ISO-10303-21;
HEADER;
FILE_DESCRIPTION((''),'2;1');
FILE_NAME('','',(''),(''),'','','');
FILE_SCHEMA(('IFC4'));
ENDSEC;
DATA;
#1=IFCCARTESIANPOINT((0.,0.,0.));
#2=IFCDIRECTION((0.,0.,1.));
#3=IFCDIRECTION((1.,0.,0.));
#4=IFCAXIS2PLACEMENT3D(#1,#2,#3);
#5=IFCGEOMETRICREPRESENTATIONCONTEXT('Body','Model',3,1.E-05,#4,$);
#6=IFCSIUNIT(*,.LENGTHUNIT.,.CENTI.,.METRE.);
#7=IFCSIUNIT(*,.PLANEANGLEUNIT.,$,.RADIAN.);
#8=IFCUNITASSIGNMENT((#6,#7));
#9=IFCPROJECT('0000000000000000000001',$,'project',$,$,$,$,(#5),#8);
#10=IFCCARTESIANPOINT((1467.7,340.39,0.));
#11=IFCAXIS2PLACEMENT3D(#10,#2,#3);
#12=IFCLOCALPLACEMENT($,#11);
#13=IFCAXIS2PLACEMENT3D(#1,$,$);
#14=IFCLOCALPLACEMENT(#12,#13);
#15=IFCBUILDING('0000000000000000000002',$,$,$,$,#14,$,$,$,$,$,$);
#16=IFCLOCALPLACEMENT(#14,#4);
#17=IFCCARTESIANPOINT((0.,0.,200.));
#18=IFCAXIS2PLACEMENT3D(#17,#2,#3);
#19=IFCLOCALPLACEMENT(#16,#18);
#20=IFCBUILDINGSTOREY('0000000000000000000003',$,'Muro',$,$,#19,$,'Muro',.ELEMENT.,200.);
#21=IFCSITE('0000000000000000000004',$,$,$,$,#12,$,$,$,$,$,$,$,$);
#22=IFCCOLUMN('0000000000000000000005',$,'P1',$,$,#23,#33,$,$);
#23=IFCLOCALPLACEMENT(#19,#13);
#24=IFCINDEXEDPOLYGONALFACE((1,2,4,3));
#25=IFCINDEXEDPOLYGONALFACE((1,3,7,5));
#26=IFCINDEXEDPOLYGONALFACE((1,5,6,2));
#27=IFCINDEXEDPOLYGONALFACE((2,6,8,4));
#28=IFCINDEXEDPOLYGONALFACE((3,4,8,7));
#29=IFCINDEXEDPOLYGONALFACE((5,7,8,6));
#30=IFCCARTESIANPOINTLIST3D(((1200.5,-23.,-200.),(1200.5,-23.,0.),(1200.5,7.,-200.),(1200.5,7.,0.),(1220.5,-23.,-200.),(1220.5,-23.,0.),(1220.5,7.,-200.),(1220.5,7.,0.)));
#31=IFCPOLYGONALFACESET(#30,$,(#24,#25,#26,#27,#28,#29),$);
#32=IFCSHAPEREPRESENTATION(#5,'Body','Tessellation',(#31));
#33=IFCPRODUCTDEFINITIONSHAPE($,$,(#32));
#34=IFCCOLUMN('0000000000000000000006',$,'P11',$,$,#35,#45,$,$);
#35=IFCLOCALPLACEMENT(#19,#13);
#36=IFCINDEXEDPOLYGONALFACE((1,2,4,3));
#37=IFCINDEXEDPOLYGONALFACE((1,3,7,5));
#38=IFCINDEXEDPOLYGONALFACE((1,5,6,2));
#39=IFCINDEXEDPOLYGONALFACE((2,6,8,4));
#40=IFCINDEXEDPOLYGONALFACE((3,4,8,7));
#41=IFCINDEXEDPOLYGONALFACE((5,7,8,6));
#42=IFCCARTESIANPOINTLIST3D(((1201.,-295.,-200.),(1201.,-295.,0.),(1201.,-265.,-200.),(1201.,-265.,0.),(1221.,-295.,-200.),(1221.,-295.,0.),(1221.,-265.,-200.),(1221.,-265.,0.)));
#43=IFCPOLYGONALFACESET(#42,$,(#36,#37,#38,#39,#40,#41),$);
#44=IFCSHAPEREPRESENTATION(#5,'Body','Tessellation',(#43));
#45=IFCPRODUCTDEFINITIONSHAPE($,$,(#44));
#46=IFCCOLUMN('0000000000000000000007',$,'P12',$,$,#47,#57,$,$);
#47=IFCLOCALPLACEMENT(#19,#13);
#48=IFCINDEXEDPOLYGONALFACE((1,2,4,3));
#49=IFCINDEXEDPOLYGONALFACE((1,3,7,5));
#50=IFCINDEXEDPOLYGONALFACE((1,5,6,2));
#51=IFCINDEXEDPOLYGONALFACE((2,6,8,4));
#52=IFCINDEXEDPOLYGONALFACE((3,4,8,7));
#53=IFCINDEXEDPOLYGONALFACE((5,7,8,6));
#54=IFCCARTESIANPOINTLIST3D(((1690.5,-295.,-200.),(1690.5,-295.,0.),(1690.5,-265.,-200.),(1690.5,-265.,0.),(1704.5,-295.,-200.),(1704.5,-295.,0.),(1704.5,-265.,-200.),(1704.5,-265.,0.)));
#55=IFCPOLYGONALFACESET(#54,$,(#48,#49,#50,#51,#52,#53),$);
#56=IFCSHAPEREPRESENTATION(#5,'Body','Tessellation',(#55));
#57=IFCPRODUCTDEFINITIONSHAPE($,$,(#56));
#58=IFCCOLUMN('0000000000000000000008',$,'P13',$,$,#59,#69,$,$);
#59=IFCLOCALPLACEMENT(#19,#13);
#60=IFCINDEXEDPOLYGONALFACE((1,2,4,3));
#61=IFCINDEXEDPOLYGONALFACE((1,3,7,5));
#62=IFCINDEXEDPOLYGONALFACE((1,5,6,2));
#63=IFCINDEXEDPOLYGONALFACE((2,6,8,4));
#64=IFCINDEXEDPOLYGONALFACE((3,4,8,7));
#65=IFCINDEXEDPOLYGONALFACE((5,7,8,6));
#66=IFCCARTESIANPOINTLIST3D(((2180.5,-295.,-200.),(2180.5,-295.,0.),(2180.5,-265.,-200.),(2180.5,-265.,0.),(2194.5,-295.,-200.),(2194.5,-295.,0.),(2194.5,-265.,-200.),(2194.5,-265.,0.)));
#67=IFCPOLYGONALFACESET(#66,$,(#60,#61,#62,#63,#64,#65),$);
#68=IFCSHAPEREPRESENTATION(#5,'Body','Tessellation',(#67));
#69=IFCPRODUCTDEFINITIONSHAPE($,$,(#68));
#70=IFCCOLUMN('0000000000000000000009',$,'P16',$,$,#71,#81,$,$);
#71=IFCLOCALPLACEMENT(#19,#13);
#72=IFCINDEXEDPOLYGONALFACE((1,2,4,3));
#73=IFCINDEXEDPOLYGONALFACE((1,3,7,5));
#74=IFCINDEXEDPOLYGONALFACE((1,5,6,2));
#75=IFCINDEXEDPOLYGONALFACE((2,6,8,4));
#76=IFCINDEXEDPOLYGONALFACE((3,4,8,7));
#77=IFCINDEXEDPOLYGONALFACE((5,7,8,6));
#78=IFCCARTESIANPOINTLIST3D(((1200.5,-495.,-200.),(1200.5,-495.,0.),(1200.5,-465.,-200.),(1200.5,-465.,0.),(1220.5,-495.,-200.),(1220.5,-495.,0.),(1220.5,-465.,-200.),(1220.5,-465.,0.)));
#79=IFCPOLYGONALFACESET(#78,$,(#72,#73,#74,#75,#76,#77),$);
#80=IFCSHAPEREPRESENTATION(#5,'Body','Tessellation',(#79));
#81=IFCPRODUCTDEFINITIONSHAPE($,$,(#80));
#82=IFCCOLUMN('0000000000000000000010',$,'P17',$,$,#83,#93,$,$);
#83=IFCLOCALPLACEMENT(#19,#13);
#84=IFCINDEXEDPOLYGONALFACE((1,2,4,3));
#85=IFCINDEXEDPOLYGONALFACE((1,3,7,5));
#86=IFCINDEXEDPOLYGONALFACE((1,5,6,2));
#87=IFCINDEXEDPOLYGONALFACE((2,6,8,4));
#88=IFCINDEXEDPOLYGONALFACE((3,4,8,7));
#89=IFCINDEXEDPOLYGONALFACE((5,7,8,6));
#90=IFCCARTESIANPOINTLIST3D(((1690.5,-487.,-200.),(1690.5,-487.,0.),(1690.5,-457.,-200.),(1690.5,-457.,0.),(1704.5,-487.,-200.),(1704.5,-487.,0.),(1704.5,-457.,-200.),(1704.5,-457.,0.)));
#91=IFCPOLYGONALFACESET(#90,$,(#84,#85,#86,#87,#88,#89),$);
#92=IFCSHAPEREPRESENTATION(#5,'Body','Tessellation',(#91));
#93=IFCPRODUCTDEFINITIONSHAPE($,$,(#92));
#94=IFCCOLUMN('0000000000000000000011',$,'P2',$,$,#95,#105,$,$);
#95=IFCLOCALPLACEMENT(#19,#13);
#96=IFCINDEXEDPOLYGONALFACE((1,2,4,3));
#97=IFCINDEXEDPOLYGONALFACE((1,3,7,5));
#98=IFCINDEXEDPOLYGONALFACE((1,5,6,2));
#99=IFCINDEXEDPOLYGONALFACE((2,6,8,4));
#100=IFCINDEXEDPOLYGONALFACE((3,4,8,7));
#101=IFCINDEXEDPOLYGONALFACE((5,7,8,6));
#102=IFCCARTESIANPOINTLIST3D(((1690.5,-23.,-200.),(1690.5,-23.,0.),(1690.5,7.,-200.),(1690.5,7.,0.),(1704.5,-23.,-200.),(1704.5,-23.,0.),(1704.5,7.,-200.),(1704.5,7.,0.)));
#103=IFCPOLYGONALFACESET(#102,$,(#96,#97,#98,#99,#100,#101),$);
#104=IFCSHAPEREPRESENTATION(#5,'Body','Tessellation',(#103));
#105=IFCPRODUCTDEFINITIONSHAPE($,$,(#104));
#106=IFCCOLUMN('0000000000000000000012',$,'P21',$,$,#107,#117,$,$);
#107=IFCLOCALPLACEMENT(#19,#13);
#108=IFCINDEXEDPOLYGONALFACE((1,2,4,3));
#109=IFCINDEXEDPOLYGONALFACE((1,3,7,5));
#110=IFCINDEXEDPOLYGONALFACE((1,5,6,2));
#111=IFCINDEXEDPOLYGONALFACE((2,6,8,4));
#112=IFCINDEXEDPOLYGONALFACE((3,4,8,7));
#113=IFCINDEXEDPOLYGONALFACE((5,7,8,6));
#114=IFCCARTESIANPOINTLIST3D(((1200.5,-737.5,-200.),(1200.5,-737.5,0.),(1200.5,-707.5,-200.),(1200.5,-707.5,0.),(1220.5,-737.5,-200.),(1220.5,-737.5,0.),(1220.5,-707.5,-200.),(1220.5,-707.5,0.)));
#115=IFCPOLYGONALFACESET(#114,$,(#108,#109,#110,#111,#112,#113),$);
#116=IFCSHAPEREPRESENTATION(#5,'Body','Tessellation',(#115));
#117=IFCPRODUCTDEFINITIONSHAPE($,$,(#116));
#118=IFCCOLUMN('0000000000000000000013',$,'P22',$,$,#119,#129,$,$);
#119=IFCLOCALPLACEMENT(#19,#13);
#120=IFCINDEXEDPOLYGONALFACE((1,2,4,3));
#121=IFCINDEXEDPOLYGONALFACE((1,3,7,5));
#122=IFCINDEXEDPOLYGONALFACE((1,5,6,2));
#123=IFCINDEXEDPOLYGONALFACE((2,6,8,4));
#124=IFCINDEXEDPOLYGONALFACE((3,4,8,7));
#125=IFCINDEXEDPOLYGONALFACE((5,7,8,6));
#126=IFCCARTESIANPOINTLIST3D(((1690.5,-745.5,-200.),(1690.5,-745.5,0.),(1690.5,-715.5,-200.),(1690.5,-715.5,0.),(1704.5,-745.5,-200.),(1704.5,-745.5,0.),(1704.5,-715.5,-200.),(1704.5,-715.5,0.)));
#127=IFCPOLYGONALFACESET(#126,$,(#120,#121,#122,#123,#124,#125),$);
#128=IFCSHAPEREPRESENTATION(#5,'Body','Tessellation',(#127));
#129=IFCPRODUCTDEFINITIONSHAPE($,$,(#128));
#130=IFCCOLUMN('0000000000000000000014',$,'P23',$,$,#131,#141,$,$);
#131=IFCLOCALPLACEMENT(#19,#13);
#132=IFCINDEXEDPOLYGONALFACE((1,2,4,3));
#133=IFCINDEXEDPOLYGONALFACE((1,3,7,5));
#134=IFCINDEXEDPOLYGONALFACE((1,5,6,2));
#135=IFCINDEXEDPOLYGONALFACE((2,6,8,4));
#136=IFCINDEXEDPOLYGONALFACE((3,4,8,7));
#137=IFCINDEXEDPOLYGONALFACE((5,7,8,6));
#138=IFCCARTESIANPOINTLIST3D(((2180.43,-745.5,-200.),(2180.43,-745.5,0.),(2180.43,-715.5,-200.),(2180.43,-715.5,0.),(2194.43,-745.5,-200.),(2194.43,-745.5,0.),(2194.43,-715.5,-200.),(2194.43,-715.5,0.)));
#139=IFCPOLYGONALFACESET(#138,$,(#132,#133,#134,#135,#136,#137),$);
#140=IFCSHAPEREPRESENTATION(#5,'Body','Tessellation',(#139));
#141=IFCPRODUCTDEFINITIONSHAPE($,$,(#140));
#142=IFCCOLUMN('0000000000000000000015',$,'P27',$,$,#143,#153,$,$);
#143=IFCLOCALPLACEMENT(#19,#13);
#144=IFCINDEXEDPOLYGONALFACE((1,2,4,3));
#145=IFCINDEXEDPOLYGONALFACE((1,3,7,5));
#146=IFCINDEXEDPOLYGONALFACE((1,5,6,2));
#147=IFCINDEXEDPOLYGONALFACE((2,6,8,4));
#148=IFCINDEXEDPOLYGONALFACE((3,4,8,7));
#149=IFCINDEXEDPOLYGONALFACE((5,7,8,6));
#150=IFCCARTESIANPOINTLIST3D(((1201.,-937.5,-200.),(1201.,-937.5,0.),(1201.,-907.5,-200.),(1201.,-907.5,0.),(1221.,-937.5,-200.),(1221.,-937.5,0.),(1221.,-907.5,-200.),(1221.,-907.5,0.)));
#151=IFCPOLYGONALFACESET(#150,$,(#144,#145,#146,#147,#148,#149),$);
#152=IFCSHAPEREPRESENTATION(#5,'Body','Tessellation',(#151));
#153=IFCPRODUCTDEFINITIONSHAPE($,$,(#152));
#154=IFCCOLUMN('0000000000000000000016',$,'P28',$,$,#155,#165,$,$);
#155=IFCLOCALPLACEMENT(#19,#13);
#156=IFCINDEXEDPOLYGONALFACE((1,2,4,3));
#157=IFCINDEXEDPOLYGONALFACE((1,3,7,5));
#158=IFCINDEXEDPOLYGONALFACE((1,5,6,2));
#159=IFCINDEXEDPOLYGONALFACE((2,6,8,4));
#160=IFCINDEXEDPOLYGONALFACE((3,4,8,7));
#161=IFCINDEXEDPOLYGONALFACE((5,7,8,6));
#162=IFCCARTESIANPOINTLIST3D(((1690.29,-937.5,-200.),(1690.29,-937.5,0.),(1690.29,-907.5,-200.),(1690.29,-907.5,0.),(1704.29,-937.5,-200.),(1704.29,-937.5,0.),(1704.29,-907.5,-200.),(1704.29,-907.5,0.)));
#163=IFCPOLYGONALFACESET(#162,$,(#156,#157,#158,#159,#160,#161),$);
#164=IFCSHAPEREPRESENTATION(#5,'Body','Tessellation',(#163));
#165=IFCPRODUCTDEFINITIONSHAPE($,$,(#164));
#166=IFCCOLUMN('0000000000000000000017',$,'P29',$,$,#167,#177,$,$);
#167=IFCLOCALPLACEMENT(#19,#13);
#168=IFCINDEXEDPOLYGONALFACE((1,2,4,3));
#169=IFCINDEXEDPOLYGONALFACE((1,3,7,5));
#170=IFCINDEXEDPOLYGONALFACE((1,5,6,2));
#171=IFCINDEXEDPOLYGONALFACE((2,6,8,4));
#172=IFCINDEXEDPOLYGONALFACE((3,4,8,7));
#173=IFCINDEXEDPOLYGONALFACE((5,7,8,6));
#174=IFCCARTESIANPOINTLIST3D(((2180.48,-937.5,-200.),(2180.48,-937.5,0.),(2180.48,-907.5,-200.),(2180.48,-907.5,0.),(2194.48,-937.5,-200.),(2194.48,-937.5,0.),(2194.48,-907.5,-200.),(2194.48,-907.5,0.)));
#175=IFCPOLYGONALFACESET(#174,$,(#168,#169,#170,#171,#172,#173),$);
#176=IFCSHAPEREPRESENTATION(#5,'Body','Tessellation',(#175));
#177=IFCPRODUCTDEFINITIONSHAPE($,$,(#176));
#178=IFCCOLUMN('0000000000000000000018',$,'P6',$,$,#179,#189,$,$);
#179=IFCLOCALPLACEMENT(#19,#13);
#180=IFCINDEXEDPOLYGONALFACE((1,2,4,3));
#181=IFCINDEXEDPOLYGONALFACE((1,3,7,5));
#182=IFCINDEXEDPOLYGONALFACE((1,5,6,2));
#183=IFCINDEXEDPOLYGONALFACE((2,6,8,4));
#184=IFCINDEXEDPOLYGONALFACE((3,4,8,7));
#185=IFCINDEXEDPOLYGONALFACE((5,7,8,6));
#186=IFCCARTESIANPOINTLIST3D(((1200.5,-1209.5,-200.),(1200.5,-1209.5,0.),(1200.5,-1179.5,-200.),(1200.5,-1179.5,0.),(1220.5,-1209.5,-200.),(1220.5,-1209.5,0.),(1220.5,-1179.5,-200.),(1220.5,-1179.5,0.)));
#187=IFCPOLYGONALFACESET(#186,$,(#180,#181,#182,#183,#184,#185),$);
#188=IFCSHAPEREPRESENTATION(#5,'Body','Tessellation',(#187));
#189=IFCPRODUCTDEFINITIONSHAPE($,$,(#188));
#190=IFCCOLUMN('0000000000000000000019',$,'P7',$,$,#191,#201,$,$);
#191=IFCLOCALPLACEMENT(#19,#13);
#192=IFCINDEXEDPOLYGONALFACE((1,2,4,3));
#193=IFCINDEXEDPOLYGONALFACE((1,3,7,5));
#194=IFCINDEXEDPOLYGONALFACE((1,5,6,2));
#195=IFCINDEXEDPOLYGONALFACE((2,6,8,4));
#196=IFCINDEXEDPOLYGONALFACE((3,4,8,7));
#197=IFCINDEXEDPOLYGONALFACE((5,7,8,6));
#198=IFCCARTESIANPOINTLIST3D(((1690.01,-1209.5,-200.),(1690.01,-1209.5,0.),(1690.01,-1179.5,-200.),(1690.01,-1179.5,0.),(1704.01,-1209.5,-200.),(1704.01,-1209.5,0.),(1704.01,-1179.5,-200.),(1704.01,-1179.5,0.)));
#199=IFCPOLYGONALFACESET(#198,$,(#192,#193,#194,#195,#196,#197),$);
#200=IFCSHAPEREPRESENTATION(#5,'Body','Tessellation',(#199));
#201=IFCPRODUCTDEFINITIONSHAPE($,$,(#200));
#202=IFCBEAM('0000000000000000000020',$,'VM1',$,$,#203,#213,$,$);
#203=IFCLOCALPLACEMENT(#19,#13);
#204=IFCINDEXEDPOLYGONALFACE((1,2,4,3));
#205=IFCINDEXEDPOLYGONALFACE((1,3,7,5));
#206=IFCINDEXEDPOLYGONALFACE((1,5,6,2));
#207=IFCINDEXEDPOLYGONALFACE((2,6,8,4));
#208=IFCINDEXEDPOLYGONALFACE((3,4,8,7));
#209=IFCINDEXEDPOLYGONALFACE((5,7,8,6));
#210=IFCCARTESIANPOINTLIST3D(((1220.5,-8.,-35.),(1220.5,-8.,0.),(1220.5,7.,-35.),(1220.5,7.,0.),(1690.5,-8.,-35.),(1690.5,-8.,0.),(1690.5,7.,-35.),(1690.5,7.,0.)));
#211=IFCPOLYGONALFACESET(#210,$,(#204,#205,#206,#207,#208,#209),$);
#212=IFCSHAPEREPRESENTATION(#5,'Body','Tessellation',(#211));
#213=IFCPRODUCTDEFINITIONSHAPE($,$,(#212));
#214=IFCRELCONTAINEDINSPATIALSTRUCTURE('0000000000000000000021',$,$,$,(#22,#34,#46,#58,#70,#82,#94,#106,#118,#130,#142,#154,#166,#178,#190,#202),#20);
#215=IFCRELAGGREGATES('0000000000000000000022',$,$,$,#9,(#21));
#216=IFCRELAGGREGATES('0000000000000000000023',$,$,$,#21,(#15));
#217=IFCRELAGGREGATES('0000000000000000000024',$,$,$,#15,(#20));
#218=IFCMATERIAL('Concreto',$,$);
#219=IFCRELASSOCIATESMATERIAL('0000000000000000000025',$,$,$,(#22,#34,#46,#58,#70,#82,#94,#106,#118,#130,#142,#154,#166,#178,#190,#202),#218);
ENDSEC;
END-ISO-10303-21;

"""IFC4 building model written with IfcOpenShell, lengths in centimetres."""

from ifc_helpers import new_model, si_unit, frame, origin, origin_with_axes, origin_2d_with_axis, place, context, project, spatial, rectangle, extrude, material, element, save


model = new_model("IFC4")

# Units and contexts
model_context = context("Model", 3, precision=1e-05, world=origin_with_axes(), identifier="Body")
ifc_project = project(units=[si_unit("LENGTHUNIT", "METRE", prefix="CENTI"), si_unit("PLANEANGLEUNIT", "RADIAN")], contexts=[model_context])

# Site, building, storey
site_placement = place(None, frame((1467.7, 340.39, 0.0), z_axis=(0.0, 0.0, 1.0), x_axis=(1.0, 0.0, 0.0)))
site = spatial("IfcSite", under=ifc_project, at=site_placement)
building_placement = place(site_placement, origin())
building = spatial("IfcBuilding", under=site, at=building_placement)
placement = place(building_placement, origin_with_axes())
storey_placement = place(placement, frame((0.0, 0.0, 200.0), z_axis=(0.0, 0.0, 1.0), x_axis=(1.0, 0.0, 0.0)))
storey = spatial("IfcBuildingStorey", under=building, at=storey_placement, Name="Muro", LongName="Muro", CompositionType="ELEMENT", Elevation=200.0)

# Columns
ifc_material = material(Name="Concreto")
for number, where, z_axis, x_axis, name in (
    (1, (1210.5, -8.0, 0.0), (0.0, 0.0, 1.0), (1.0, 0.0, 0.0), "P1"),
    (2, (1211.0, -280.0, 0.0), (0.0, 0.0, 1.0), (1.0, 0.0, 0.0), "P11"),
):
    element("IfcColumn", number, at=place(storey_placement, frame(where, z_axis=z_axis, x_axis=x_axis)), inside=storey, material=ifc_material, Name=name, context=model_context, shape_type="SolidModel", body=[
        extrude(rectangle(XDim=20.0, YDim=30.0, at=origin_2d_with_axis()), origin_with_axes(), (0.0, 0.0, -1.0), 200.0),
    ])
for number, where, z_axis, x_axis, name in (
    (3, (1697.5, -280.0, 0.0), (0.0, 0.0, 1.0), (1.0, 0.0, 0.0), "P12"),
    (4, (2187.5, -280.0, 0.0), (0.0, 0.0, 1.0), (1.0, 0.0, 0.0), "P13"),
):
    element("IfcColumn", number, at=place(storey_placement, frame(where, z_axis=z_axis, x_axis=x_axis)), inside=storey, material=ifc_material, Name=name, context=model_context, shape_type="SolidModel", body=[
        extrude(rectangle(XDim=14.0, YDim=30.0, at=origin_2d_with_axis()), origin_with_axes(), (0.0, 0.0, -1.0), 200.0),
    ])
column_1_placement = place(storey_placement, frame((1210.5, -480.0, 0.0), z_axis=(0.0, 0.0, 1.0), x_axis=(1.0, 0.0, 0.0)))
element("IfcColumn", 5, at=column_1_placement, inside=storey, material=ifc_material, Name="P16", context=model_context, shape_type="SolidModel", body=[
    extrude(rectangle(XDim=20.0, YDim=30.0, at=origin_2d_with_axis()), origin_with_axes(), (0.0, 0.0, -1.0), 200.0),
])
column_2_placement = place(storey_placement, frame((1697.5, -472.0, 0.0), z_axis=(0.0, 0.0, 1.0), x_axis=(1.0, 0.0, 0.0)))
element("IfcColumn", 6, at=column_2_placement, inside=storey, material=ifc_material, Name="P17", context=model_context, shape_type="SolidModel", body=[
    extrude(rectangle(XDim=14.0, YDim=30.0, at=origin_2d_with_axis()), frame((0.0, 0.0, 0.0), z_axis=(0.0, 0.0, 1.0), x_axis=(-1.0, 0.0, 0.0)), (0.0, 0.0, -1.0), 200.0),
])
column_3_placement = place(storey_placement, frame((1697.5, -8.0, 0.0), z_axis=(0.0, 0.0, 1.0), x_axis=(1.0, 0.0, 0.0)))
element("IfcColumn", 7, at=column_3_placement, inside=storey, material=ifc_material, Name="P2", context=model_context, shape_type="SolidModel", body=[
    extrude(rectangle(XDim=14.0, YDim=30.0, at=origin_2d_with_axis()), origin_with_axes(), (0.0, 0.0, -1.0), 200.0),
])
column_4_placement = place(storey_placement, frame((1210.5, -722.5, 0.0), z_axis=(0.0, 0.0, 1.0), x_axis=(1.0, 0.0, 0.0)))
element("IfcColumn", 8, at=column_4_placement, inside=storey, material=ifc_material, Name="P21", context=model_context, shape_type="SolidModel", body=[
    extrude(rectangle(XDim=20.0, YDim=30.0, at=origin_2d_with_axis()), origin_with_axes(), (0.0, 0.0, -1.0), 200.0),
])
column_5_placement = place(storey_placement, frame((1697.5, -730.5, 0.0), z_axis=(0.0, 0.0, 1.0), x_axis=(1.0, 0.0, 0.0)))
element("IfcColumn", 9, at=column_5_placement, inside=storey, material=ifc_material, Name="P22", context=model_context, shape_type="SolidModel", body=[
    extrude(rectangle(XDim=14.0, YDim=30.0, at=origin_2d_with_axis()), frame((0.0, 0.0, 0.0), z_axis=(0.0, 0.0, 1.0), x_axis=(-1.0, 0.0, 0.0)), (0.0, 0.0, -1.0), 200.0),
])
column_6_placement = place(storey_placement, frame((2187.43, -730.5, 0.0), z_axis=(0.0, 0.0, 1.0), x_axis=(1.0, 0.0, 0.0)))
element("IfcColumn", 10, at=column_6_placement, inside=storey, material=ifc_material, Name="P23", context=model_context, shape_type="SolidModel", body=[
    extrude(rectangle(XDim=14.0, YDim=30.0, at=origin_2d_with_axis()), origin_with_axes(), (0.0, 0.0, -1.0), 200.0),
])
column_7_placement = place(storey_placement, frame((1211.0, -922.5, 0.0), z_axis=(0.0, 0.0, 1.0), x_axis=(1.0, 0.0, 0.0)))
element("IfcColumn", 11, at=column_7_placement, inside=storey, material=ifc_material, Name="P27", context=model_context, shape_type="SolidModel", body=[
    extrude(rectangle(XDim=20.0, YDim=30.0, at=origin_2d_with_axis()), origin_with_axes(), (0.0, 0.0, -1.0), 200.0),
])
for number, where, z_axis, x_axis, name in (
    (12, (1697.29, -922.5, 0.0), (0.0, 0.0, 1.0), (1.0, 0.0, 0.0), "P28"),
    (13, (2187.48, -922.5, 0.0), (0.0, 0.0, 1.0), (1.0, 0.0, 0.0), "P29"),
):
    element("IfcColumn", number, at=place(storey_placement, frame(where, z_axis=z_axis, x_axis=x_axis)), inside=storey, material=ifc_material, Name=name, context=model_context, shape_type="SolidModel", body=[
        extrude(rectangle(XDim=14.0, YDim=30.0, at=origin_2d_with_axis()), origin_with_axes(), (0.0, 0.0, -1.0), 200.0),
    ])
column_8_placement = place(storey_placement, frame((1210.5, -1194.5, 0.0), z_axis=(0.0, 0.0, 1.0), x_axis=(1.0, 0.0, 0.0)))
element("IfcColumn", 14, at=column_8_placement, inside=storey, material=ifc_material, Name="P6", context=model_context, shape_type="SolidModel", body=[
    extrude(rectangle(XDim=20.0, YDim=30.0, at=origin_2d_with_axis()), origin_with_axes(), (0.0, 0.0, -1.0), 200.0),
])
column_9_placement = place(storey_placement, frame((1697.01, -1194.5, 0.0), z_axis=(0.0, 0.0, 1.0), x_axis=(1.0, 0.0, 0.0)))
element("IfcColumn", 15, at=column_9_placement, inside=storey, material=ifc_material, Name="P7", context=model_context, shape_type="SolidModel", body=[
    extrude(rectangle(XDim=14.0, YDim=30.0, at=origin_2d_with_axis()), origin_with_axes(), (0.0, 0.0, -1.0), 200.0),
])

# Beam
beam_1_placement = place(storey_placement, frame((1455.5, -0.5, 0.0), z_axis=(0.0, 0.0, 1.0), x_axis=(1.0, 0.0, 0.0)))
element("IfcBeam", 16, at=beam_1_placement, inside=storey, material=ifc_material, Name="VM1", context=model_context, shape_type="SolidModel", body=[
    extrude(rectangle(XDim=15.0, YDim=35.0, at=origin_2d_with_axis()), frame((-235.0, 0.0, -17.5), z_axis=(1.0, 0.0, 0.0), x_axis=(0.0, 1.0, 0.0)), (0.0, 0.0, 1.0), 470.0),
])

save(model, "model.ifc")
